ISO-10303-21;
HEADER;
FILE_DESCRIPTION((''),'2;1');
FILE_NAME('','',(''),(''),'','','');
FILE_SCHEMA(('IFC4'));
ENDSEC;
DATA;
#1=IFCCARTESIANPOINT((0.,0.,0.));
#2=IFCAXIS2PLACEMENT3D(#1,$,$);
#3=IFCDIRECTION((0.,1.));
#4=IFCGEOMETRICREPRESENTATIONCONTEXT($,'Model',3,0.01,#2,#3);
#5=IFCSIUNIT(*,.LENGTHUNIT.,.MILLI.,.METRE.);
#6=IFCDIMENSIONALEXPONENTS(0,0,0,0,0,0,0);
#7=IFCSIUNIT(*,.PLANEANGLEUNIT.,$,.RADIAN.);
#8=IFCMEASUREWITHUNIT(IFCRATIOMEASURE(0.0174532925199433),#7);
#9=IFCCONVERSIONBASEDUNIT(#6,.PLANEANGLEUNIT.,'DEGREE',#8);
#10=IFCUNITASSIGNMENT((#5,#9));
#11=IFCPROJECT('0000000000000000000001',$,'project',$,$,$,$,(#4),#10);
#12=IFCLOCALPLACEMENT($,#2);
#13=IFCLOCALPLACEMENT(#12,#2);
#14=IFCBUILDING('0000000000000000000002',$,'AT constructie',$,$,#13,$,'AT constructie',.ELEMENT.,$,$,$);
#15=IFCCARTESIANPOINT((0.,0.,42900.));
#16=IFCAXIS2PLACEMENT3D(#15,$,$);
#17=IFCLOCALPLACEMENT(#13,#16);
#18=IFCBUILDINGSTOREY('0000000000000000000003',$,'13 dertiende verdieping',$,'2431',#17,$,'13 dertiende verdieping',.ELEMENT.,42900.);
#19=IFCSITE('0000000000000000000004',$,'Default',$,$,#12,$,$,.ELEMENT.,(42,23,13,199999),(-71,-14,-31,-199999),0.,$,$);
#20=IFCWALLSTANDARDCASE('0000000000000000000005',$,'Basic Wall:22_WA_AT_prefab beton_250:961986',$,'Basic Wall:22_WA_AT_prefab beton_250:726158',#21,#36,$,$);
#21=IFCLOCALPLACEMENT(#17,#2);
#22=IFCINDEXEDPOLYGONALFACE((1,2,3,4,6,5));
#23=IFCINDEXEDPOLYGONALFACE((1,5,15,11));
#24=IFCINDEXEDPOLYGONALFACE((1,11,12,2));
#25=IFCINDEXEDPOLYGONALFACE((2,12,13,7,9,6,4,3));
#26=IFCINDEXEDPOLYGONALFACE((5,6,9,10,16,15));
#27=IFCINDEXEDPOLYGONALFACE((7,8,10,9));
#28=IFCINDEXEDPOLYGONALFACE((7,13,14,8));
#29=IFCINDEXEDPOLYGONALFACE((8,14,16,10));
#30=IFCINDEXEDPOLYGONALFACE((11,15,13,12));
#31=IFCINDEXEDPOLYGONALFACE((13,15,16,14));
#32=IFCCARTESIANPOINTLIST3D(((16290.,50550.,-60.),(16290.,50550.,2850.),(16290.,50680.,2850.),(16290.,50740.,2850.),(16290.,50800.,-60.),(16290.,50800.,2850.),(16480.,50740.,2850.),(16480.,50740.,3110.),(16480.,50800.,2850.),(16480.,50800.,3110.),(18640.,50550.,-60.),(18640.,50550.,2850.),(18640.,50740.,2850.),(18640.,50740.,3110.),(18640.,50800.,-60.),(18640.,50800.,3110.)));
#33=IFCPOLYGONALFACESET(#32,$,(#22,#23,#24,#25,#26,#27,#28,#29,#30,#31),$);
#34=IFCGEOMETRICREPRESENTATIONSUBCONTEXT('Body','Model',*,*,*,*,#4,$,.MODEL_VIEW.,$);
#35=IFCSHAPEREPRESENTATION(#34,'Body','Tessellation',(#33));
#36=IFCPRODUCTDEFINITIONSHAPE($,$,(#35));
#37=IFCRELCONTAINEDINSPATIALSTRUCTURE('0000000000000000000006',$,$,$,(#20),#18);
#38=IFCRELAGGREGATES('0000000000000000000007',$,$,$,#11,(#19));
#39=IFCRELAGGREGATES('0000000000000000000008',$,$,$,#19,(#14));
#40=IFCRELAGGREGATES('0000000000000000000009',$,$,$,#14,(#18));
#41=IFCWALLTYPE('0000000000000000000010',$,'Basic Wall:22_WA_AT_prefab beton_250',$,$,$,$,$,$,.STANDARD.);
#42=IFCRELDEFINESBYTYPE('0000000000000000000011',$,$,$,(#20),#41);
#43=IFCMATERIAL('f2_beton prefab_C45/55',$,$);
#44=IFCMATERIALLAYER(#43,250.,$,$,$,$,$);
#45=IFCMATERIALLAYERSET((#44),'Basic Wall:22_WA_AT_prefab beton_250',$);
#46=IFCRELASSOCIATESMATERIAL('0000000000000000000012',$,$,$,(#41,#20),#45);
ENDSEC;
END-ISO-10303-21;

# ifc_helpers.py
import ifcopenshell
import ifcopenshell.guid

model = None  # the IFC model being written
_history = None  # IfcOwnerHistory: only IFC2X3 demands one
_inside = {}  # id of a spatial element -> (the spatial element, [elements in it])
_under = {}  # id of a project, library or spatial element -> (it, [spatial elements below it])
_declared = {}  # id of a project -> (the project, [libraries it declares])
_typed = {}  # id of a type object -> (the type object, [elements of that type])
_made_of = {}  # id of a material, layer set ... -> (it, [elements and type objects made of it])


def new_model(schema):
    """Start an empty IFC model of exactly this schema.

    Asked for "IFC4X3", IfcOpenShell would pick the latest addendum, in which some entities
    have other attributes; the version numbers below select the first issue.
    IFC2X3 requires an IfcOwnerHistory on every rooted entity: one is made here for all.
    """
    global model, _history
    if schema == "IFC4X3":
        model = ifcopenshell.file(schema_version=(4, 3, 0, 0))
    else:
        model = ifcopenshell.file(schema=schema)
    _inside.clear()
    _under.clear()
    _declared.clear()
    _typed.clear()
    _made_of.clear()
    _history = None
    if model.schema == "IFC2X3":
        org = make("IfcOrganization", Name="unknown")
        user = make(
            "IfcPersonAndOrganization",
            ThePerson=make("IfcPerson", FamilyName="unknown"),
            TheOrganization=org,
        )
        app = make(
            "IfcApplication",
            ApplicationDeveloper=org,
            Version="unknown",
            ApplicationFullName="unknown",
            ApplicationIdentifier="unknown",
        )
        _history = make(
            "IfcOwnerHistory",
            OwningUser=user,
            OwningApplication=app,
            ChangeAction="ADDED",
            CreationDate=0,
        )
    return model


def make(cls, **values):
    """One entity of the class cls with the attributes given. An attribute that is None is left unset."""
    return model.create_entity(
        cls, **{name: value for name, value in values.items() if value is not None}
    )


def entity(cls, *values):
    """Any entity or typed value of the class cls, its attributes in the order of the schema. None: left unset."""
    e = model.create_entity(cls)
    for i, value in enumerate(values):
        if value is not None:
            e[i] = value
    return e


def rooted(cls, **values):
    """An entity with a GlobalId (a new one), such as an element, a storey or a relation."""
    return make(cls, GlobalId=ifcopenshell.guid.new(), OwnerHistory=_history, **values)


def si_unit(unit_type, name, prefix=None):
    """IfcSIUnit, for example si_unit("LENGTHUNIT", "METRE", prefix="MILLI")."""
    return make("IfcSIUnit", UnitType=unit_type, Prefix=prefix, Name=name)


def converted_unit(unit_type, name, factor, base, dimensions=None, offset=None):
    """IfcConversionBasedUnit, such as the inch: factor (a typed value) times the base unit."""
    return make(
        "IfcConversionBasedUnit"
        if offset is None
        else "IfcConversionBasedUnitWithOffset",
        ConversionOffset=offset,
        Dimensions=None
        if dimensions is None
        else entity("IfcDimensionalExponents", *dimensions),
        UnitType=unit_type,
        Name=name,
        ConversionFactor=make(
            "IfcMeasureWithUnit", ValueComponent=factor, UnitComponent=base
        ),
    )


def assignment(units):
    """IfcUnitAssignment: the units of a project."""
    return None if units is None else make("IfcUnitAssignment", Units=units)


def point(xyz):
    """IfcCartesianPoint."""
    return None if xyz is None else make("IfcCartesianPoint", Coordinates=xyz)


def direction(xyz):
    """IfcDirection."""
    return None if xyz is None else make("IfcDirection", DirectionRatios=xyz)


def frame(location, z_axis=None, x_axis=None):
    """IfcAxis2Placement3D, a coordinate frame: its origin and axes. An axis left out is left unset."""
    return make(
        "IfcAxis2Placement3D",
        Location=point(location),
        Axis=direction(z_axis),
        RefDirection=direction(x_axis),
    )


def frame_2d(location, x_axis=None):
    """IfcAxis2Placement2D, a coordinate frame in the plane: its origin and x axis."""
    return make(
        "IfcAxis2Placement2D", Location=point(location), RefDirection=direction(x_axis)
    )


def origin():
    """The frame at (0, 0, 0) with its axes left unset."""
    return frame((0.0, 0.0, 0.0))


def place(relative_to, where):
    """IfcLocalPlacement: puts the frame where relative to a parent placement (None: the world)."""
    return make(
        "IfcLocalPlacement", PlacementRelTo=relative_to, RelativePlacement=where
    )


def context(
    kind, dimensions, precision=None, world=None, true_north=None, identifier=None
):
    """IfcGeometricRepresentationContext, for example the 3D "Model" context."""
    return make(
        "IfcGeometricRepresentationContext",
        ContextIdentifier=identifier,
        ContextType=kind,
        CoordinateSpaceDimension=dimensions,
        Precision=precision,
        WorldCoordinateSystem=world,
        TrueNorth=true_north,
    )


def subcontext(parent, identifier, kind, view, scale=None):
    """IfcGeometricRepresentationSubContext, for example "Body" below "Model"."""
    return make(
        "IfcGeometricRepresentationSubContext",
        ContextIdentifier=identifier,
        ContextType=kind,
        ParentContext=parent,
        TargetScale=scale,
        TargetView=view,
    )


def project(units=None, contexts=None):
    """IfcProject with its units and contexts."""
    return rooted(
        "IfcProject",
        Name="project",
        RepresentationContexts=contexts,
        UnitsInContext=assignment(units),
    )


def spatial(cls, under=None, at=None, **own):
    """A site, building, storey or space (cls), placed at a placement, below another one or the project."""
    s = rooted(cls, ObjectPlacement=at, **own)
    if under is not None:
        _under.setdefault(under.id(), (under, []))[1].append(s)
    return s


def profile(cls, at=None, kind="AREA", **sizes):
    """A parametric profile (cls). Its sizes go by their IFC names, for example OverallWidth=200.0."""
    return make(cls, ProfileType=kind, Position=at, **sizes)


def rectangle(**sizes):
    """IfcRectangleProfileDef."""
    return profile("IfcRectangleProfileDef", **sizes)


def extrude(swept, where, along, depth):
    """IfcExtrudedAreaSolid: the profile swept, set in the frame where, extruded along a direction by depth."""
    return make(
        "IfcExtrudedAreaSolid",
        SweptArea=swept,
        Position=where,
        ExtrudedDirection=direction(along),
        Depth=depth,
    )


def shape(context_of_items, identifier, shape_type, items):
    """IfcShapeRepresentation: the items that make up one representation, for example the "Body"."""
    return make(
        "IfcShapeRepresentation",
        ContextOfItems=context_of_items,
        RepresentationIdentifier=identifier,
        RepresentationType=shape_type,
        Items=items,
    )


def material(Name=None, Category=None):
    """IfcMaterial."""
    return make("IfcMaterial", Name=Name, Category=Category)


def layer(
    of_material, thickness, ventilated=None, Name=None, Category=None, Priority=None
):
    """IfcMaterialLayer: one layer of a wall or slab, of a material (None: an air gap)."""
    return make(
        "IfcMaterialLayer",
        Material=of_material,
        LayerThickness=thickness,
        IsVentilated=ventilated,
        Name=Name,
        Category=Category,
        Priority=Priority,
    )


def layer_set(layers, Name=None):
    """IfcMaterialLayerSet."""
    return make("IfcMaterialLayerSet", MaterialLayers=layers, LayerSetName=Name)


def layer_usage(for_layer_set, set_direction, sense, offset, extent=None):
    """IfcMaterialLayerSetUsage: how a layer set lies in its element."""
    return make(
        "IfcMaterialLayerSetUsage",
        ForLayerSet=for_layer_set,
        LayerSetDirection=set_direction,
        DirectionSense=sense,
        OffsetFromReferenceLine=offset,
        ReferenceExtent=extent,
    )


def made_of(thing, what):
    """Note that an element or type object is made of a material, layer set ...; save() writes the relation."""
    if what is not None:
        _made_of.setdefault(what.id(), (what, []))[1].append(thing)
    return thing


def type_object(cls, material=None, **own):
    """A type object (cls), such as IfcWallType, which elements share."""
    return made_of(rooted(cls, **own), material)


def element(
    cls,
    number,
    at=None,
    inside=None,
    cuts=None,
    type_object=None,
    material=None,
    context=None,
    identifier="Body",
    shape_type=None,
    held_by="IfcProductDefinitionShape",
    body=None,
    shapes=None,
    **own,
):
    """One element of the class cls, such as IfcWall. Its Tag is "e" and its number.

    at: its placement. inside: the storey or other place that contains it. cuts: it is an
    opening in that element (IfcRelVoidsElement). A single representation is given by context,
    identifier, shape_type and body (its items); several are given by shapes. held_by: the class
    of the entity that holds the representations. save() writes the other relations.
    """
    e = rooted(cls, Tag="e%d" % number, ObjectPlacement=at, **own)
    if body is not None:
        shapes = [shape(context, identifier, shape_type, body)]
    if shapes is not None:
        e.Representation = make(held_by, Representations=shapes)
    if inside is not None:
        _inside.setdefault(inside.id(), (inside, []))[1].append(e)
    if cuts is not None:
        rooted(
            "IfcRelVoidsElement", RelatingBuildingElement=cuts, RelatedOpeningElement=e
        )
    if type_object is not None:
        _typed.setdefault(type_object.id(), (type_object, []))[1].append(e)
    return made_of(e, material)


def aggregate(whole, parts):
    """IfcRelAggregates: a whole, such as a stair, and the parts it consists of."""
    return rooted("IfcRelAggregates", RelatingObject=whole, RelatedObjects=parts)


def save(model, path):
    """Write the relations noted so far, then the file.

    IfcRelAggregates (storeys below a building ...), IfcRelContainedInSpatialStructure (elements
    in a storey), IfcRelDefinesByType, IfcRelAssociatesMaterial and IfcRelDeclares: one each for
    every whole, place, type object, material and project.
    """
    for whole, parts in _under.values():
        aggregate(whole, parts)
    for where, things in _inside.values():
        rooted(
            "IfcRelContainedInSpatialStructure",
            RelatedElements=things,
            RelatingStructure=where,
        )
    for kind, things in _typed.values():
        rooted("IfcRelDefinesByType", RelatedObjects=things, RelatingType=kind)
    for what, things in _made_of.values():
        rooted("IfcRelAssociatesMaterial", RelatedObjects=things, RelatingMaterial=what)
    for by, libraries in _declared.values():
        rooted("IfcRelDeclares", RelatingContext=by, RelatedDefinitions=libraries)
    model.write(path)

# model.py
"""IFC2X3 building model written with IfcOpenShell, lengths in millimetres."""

from ifc_helpers import new_model, entity, si_unit, converted_unit, direction, frame, frame_2d, origin, place, context, subcontext, project, spatial, rectangle, extrude, material, layer, layer_set, layer_usage, type_object, element, save


model = new_model("IFC2X3")

# Units and contexts
model_context = context("Model", 3, precision=0.01, world=origin(), true_north=direction((0.0, 1.0)))
body_context = subcontext(model_context, "Body", "Model", "MODEL_VIEW")
ifc_project = project(units=[si_unit("LENGTHUNIT", "METRE", prefix="MILLI"), converted_unit("PLANEANGLEUNIT", "DEGREE", entity("IfcRatioMeasure", 0.0174532925199433), si_unit("PLANEANGLEUNIT", "RADIAN"), dimensions=[0, 0, 0, 0, 0, 0, 0])], contexts=[model_context])

# Site, building, storey
site_placement = place(None, origin())
site = spatial("IfcSite", under=ifc_project, at=site_placement, Name="Default", CompositionType="ELEMENT", RefLatitude=(42, 23, 13, 199999), RefLongitude=(-71, -14, -31, -199999), RefElevation=0.0)
building_placement = place(site_placement, origin())
building = spatial("IfcBuilding", under=site, at=building_placement, Name="AT constructie", LongName="AT constructie", CompositionType="ELEMENT")
storey_placement = place(building_placement, frame((0.0, 0.0, 42900.0)))
storey = spatial("IfcBuildingStorey", under=building, at=storey_placement, Name="13 dertiende verdieping", ObjectType="2431", LongName="13 dertiende verdieping", CompositionType="ELEMENT", Elevation=42900.0)

# Wall, openings
ifc_material_1 = material(Name="f2_beton prefab_C45/55")
ifc_layer = layer(ifc_material_1, 250.0)
ifc_layer_set = layer_set([ifc_layer], Name="Basic Wall:22_WA_AT_prefab beton_250")
wall_type = type_object("IfcWallType", Name="Basic Wall:22_WA_AT_prefab beton_250", PredefinedType="STANDARD", material=ifc_layer_set)
ifc_layer_usage_1 = layer_usage(ifc_layer_set, "AXIS2", "NEGATIVE", 125.0)
wall_1_placement = place(storey_placement, frame((16290.0, 50675.0, -60.0)))
wall_1 = element("IfcWallStandardCase", 1, at=wall_1_placement, inside=storey, type_object=wall_type, material=ifc_layer_usage_1, Name="Basic Wall:22_WA_AT_prefab beton_250:961986", ObjectType="Basic Wall:22_WA_AT_prefab beton_250:726158", context=body_context, shape_type="SweptSolid", body=[
    extrude(rectangle(XDim=2350.0, YDim=250.0, at=frame_2d((1175.0, 0.0), x_axis=(-1.0, 0.0))), origin(), (0.0, 0.0, 1.0), 3170.0),
])
opening_1_placement = place(wall_1_placement, origin())
element("IfcOpeningElement", 2, at=opening_1_placement, cuts=wall_1, ObjectType="Recess", context=body_context, shape_type="SweptSolid", body=[
    extrude(rectangle(XDim=260.0, YDim=2350.0, at=frame_2d((0.0, 0.0), x_axis=(1.0, 0.0))), frame((1175.0, -125.0, 3040.0), z_axis=(0.0, 1.0, 0.0), x_axis=(0.0, 0.0, -1.0)), (0.0, 0.0, 1.0), 190.0),
])
opening_2_placement = place(wall_1_placement, origin())
element("IfcOpeningElement", 3, at=opening_2_placement, cuts=wall_1, ObjectType="Opening", context=body_context, shape_type="SweptSolid", body=[
    extrude(rectangle(XDim=260.0, YDim=190.0, at=frame_2d((0.0, 0.0), x_axis=(0.0, 1.0))), frame((95.0, 5.0, 3040.0), z_axis=(0.0, 1.0, 0.0), x_axis=(1.0, 0.0, 0.0)), (0.0, 0.0, 1.0), 3230.6),
])

save(model, "model.ifc")
